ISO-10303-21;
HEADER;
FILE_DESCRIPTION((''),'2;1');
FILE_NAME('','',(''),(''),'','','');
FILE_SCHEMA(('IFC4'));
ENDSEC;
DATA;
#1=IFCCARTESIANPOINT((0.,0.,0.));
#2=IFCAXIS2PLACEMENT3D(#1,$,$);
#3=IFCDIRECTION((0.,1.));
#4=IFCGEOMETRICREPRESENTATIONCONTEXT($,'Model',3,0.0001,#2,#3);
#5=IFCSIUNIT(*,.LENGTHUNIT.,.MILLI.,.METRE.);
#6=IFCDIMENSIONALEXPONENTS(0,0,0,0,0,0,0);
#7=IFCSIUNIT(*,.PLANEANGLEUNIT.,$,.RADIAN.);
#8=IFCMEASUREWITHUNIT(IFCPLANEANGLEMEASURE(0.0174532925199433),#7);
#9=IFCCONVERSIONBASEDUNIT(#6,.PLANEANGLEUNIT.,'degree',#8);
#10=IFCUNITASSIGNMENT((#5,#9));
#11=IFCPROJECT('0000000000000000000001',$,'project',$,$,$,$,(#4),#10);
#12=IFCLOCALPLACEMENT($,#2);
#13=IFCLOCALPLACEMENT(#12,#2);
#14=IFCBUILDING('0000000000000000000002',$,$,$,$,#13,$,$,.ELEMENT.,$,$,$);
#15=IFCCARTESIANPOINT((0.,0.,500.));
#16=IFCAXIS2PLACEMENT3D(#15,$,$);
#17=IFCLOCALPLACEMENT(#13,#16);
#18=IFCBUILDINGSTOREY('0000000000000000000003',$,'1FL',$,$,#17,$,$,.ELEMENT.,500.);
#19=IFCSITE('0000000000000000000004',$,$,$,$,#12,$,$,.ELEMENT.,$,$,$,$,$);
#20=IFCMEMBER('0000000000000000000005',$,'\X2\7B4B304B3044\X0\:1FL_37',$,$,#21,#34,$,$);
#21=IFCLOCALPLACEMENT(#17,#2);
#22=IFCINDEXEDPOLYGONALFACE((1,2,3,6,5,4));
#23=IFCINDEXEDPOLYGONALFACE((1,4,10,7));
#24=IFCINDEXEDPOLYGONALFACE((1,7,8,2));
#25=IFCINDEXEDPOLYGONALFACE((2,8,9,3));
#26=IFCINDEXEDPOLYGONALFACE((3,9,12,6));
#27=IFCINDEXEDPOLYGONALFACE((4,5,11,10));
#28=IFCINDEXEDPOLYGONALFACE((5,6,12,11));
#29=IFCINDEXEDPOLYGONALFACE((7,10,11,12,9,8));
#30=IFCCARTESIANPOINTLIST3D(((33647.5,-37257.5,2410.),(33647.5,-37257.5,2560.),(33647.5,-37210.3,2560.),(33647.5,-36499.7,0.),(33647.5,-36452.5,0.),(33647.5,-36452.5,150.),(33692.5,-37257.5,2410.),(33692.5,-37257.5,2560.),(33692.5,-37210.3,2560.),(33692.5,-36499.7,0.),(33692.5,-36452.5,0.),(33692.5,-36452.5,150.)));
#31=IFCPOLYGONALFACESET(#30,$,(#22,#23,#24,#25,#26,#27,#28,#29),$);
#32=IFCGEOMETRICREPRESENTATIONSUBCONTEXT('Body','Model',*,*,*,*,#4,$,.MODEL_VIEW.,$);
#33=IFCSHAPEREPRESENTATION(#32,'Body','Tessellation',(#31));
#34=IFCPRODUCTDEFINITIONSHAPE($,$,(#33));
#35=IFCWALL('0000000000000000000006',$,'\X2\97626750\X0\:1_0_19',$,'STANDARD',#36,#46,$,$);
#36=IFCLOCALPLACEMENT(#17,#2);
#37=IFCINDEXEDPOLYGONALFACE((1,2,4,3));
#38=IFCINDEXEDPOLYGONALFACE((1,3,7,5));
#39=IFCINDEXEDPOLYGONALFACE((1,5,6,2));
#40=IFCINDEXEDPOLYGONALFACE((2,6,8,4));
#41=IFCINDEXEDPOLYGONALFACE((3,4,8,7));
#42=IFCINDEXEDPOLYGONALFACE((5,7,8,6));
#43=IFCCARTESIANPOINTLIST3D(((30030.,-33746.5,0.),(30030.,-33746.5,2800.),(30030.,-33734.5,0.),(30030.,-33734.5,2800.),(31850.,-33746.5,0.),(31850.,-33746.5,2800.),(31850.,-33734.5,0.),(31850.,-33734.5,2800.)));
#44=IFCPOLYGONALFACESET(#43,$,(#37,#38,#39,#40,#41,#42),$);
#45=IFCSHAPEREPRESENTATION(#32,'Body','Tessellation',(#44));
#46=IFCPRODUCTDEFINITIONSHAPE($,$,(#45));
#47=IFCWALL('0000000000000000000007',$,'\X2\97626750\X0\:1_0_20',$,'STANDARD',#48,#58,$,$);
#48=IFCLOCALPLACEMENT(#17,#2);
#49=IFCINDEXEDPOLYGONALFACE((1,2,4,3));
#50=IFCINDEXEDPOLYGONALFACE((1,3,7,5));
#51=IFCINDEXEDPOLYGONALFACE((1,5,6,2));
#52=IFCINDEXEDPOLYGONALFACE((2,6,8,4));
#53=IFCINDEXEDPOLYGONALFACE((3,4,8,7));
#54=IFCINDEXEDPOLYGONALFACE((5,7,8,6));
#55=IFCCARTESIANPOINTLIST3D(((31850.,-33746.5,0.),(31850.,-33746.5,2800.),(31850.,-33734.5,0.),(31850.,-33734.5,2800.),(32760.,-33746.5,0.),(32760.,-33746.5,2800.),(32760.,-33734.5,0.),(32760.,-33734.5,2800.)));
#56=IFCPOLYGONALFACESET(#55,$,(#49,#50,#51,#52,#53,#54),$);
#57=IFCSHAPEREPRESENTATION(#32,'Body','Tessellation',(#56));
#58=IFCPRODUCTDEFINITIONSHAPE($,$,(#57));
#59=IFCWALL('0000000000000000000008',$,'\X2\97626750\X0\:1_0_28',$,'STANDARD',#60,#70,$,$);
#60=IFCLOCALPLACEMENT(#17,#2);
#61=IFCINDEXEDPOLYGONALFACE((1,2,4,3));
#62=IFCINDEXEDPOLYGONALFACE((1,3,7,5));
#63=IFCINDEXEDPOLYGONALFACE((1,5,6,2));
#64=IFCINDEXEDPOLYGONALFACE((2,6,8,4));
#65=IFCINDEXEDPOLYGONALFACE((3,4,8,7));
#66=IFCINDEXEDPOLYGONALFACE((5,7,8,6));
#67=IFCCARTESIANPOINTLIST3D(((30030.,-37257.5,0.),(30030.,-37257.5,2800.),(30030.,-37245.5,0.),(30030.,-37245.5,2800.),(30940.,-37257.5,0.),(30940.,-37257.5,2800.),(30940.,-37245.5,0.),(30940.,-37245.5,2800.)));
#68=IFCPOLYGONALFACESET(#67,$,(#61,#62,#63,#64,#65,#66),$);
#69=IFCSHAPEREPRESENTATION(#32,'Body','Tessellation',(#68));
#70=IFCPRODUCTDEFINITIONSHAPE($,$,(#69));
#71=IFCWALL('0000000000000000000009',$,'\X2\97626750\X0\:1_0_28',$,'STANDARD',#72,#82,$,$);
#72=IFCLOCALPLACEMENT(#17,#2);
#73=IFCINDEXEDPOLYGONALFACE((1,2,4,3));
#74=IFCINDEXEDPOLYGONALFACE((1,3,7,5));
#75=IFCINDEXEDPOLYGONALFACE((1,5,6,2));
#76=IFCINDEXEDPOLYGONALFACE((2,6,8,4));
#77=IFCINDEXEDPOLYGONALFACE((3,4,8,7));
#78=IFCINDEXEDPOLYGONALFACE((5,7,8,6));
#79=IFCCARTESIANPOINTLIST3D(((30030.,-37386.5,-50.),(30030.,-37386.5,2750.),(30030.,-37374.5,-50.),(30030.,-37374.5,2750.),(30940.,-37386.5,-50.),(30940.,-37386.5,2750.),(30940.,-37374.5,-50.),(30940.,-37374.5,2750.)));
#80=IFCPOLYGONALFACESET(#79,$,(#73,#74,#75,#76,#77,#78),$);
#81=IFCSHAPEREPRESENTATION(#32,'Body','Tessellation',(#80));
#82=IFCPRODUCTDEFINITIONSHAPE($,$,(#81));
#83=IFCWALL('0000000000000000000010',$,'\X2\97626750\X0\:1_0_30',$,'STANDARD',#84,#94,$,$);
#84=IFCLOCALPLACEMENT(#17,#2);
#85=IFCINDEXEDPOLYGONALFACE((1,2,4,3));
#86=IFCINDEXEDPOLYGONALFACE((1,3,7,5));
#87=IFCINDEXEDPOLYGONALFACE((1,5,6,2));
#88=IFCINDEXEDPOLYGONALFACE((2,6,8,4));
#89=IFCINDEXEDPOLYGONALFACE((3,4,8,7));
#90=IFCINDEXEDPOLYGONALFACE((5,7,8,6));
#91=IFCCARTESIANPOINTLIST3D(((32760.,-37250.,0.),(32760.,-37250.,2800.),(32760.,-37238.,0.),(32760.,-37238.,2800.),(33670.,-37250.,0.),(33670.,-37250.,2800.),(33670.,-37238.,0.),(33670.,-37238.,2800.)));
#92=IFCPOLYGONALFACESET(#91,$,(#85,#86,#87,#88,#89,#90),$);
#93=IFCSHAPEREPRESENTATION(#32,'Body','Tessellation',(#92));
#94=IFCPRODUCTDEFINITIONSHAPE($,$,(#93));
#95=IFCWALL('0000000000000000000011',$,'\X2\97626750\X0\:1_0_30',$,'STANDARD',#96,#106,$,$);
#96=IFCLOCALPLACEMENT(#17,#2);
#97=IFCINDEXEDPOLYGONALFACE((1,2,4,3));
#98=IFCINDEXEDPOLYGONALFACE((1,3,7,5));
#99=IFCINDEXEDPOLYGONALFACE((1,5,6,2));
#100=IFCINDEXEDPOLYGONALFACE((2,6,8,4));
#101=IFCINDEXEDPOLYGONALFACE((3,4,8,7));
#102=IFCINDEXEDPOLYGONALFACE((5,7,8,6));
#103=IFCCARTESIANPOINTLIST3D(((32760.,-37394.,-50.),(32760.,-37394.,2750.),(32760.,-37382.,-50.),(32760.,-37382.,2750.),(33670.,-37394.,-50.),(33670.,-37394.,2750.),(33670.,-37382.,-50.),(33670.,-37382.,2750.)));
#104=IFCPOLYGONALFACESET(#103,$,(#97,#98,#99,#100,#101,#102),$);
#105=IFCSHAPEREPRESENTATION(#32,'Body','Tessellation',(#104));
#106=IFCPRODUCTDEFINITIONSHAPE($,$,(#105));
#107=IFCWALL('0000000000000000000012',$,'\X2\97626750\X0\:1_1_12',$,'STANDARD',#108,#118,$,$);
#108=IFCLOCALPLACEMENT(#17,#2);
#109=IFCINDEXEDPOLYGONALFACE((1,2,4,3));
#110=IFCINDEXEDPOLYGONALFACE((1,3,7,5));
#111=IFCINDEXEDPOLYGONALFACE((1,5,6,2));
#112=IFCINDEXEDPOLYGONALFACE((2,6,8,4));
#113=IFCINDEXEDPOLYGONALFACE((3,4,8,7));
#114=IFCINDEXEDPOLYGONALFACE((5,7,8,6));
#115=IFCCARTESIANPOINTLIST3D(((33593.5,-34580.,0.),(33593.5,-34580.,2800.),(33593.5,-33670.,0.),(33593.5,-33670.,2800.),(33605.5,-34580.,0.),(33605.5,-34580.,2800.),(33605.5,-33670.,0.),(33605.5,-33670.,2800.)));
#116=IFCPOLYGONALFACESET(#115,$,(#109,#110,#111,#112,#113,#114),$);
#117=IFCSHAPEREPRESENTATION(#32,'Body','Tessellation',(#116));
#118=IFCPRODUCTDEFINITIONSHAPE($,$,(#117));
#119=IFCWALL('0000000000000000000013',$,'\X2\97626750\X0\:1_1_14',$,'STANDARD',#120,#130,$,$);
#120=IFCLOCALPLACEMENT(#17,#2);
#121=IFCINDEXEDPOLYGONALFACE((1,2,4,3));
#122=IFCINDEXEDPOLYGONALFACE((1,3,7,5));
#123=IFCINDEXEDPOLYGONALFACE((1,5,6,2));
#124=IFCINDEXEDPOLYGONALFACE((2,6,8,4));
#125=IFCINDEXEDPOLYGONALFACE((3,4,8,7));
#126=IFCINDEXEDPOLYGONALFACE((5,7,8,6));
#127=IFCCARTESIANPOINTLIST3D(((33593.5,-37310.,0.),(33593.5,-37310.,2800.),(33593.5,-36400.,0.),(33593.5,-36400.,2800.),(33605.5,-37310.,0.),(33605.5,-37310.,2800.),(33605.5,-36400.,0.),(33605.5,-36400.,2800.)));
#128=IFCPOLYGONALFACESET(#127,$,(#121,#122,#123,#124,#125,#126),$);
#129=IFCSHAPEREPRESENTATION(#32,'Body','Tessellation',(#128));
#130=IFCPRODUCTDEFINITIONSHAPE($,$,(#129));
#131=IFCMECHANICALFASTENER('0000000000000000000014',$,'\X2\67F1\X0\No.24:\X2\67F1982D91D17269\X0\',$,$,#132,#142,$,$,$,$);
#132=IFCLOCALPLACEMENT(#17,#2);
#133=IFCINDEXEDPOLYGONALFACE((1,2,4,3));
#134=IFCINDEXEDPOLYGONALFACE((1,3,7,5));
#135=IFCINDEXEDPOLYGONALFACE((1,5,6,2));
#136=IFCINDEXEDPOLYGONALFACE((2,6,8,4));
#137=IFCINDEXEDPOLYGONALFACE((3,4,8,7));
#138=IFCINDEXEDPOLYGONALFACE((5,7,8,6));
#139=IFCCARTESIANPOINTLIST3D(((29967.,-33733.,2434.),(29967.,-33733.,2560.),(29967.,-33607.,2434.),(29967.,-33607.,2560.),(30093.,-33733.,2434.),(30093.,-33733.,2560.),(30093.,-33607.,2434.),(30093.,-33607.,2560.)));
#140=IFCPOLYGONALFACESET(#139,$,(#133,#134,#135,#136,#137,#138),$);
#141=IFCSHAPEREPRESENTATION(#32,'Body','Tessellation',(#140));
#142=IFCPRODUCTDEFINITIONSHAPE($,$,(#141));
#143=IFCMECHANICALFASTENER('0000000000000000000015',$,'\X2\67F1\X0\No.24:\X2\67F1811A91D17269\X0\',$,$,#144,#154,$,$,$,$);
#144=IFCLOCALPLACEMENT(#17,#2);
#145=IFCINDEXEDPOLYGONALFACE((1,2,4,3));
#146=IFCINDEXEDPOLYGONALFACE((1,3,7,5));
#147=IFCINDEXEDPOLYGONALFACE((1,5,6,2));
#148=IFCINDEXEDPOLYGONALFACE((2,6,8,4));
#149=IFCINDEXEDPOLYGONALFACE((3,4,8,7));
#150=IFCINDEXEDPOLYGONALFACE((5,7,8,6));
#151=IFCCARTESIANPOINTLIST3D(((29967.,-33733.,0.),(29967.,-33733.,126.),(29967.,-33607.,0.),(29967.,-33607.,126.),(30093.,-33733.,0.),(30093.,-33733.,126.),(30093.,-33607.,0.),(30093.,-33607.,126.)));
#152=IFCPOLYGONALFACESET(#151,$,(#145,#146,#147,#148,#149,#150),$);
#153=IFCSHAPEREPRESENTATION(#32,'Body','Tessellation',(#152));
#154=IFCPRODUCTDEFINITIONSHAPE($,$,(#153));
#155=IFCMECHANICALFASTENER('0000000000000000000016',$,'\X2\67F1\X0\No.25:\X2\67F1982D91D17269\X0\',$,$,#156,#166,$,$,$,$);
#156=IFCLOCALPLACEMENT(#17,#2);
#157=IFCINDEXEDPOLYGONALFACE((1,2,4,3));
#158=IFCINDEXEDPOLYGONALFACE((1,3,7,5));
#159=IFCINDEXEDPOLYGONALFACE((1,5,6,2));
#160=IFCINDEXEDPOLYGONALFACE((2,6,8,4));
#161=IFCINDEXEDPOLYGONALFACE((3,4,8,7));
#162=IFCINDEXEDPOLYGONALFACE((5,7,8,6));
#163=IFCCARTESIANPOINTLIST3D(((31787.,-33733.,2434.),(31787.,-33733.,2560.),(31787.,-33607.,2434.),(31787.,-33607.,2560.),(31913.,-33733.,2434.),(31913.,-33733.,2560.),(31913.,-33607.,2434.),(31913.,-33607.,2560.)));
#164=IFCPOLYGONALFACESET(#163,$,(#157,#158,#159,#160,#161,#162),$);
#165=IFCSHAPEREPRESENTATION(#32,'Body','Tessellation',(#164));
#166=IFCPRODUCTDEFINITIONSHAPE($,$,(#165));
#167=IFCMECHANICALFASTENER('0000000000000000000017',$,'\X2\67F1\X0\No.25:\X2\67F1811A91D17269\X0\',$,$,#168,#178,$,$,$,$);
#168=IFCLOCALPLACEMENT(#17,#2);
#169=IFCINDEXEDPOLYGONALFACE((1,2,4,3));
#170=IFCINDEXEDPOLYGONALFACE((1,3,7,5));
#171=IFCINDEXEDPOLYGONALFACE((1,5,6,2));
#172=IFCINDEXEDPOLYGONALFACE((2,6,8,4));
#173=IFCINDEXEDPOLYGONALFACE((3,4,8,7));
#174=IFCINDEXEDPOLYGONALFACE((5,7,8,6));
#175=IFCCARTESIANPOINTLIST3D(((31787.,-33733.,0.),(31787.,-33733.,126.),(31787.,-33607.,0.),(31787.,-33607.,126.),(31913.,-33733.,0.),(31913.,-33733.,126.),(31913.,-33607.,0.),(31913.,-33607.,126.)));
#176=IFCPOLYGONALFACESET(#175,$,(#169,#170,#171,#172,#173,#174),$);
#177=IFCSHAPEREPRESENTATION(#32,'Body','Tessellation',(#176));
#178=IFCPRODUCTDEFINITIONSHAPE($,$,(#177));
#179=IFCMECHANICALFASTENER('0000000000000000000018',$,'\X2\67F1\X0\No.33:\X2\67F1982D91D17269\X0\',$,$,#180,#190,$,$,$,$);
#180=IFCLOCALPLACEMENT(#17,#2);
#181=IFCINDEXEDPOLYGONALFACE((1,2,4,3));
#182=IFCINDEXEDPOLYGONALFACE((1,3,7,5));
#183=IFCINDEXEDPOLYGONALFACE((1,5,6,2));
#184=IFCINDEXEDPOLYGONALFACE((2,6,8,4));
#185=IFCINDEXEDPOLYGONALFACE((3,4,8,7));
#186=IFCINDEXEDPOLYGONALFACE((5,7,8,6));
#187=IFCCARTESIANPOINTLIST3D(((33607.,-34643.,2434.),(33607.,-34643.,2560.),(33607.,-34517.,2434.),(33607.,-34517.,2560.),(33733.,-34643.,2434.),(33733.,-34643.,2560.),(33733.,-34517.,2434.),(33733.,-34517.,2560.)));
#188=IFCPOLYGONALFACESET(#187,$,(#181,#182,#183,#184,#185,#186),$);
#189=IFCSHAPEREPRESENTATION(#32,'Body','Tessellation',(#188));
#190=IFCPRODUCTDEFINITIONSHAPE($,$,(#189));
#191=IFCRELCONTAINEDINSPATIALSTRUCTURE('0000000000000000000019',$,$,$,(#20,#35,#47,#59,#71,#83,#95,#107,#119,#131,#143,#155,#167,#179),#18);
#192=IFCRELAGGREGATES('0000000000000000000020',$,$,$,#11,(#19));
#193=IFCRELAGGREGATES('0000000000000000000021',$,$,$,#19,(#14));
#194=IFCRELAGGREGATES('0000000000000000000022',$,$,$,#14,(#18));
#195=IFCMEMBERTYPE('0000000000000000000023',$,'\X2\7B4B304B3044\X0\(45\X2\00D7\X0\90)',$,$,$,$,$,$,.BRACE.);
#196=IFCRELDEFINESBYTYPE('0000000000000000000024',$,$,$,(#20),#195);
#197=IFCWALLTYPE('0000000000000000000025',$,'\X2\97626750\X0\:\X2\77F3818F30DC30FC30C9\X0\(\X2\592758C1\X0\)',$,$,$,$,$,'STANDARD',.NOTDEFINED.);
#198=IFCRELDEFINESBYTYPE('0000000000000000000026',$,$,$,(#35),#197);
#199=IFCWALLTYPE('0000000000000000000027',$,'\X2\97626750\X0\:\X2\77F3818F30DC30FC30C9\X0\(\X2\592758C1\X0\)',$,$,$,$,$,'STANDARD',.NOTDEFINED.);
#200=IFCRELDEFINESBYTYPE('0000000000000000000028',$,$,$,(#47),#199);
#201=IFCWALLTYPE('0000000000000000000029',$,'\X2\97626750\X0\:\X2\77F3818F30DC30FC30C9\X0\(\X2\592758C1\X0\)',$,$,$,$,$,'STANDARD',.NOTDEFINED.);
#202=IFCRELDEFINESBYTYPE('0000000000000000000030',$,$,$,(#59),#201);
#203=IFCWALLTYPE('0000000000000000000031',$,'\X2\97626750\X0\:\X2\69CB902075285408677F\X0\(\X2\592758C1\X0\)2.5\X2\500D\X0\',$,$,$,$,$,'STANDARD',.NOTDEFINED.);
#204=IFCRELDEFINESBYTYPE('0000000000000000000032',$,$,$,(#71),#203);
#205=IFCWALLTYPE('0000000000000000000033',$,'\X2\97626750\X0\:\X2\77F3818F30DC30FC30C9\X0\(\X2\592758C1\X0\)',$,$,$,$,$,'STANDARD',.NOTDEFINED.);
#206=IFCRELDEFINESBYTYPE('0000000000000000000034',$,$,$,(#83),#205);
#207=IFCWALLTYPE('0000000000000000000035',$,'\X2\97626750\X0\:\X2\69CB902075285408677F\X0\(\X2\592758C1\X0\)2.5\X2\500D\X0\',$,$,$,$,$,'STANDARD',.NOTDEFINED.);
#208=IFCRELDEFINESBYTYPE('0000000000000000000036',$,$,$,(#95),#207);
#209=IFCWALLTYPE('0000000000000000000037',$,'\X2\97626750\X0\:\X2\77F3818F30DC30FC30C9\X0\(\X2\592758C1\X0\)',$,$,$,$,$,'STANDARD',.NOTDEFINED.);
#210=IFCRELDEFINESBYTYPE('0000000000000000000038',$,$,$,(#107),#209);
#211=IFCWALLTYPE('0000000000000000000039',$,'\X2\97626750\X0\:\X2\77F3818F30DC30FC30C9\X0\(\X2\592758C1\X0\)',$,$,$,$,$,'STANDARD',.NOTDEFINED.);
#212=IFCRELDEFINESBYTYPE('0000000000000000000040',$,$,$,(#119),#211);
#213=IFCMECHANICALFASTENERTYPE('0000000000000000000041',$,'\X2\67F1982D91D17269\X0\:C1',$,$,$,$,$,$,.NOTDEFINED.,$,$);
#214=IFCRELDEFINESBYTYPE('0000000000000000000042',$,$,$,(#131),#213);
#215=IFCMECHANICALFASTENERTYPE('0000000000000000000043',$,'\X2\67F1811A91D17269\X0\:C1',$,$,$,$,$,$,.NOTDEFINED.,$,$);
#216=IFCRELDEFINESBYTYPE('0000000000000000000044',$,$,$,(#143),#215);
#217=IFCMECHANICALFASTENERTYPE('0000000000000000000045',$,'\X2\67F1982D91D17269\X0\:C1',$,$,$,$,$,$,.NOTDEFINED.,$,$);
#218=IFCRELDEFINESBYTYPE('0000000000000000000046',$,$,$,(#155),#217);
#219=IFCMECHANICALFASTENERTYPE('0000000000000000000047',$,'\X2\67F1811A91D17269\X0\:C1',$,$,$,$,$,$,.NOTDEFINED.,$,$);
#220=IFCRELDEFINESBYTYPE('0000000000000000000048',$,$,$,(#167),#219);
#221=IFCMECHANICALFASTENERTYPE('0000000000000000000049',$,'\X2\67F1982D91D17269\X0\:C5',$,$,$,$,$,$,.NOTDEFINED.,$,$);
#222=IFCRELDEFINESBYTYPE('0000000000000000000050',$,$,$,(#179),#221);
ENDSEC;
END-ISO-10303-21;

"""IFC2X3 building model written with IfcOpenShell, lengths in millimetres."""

from ifc_helpers import new_model, entity, si_unit, converted_unit, direction, frame, origin, origin_with_axes, origin_2d, place, context, subcontext, project, spatial, polyline, rectangle, outline, extrude, type_object, element, save


model = new_model("IFC2X3")

# Units and contexts
model_context = context("Model", 3, precision=0.0001, world=origin(), true_north=direction((0.0, 1.0)))
body_context = subcontext(model_context, "Body", "Model", "MODEL_VIEW")
ifc_project = project(units=[si_unit("LENGTHUNIT", "METRE", prefix="MILLI"), converted_unit("PLANEANGLEUNIT", "degree", entity("IfcPlaneAngleMeasure", 0.0174532925199433), si_unit("PLANEANGLEUNIT", "RADIAN"), dimensions=[0, 0, 0, 0, 0, 0, 0])], contexts=[model_context])

# Site, building, storey
site_placement = place(None, origin())
site = spatial("IfcSite", under=ifc_project, at=site_placement, CompositionType="ELEMENT")
building_placement = place(site_placement, origin())
building = spatial("IfcBuilding", under=site, at=building_placement, CompositionType="ELEMENT")
storey_placement = place(building_placement, frame((0.0, 0.0, 500.0)))
storey = spatial("IfcBuildingStorey", under=building, at=storey_placement, Name="1FL", CompositionType="ELEMENT", Elevation=500.0)

# Member
member_type_1 = type_object("IfcMemberType", Name="筋かい(45×90)", PredefinedType="BRACE")
member_1_placement = place(storey_placement, frame((33670.0, -36452.5, 0.0), z_axis=(0.0, -0.299972, 0.953948), x_axis=(0.0, 0.953948, 0.299972)))
element("IfcMember", 1, at=member_1_placement, inside=storey, type_object=member_type_1, Name="筋かい:1FL_37", context=body_context, shape_type="SweptSolid", body=[
    extrude(outline(polyline([(0.0, 0.0), (14.2, -45.0), (2540.5, -45.0), (2683.6, 0.0), (2669.4, 45.0), (143.1, 45.0), (0.0, 0.0)])), frame((0.0, -22.5, 0.0), z_axis=(0.0, 1.0, 0.0), x_axis=(0.0, 0.0, 1.0)), (0.0, 0.0, 1.0), 45.0),
])

# Walls
wall_type_1 = type_object("IfcWallType", Name="面材:石膏ボード(大壁)", ElementType="STANDARD", PredefinedType="NOTDEFINED")
wall_1_placement = place(storey_placement, frame((30940.0, -33734.5, 0.0), z_axis=(0.0, -1.0, 0.0), x_axis=(1.0, 0.0, 0.0)))
element("IfcWall", 2, at=wall_1_placement, inside=storey, type_object=wall_type_1, Name="面材:1_0_19", ObjectType="STANDARD", context=body_context, shape_type="SweptSolid", body=[
    extrude(outline(polyline([(910.0, 0.0, 0.0), (-910.0, 0.0, 0.0), (-910.0, 2800.0, 0.0), (910.0, 2800.0, 0.0), (910.0, 0.0, 0.0)])), origin_with_axes(), (0.0, 0.0, 1.0), 12.0),
])
wall_type_2 = type_object("IfcWallType", Name="面材:石膏ボード(大壁)", ElementType="STANDARD", PredefinedType="NOTDEFINED")
wall_2_placement = place(storey_placement, frame((32305.0, -33734.5, 0.0), z_axis=(0.0, -1.0, 0.0), x_axis=(1.0, 0.0, 0.0)))
element("IfcWall", 3, at=wall_2_placement, inside=storey, type_object=wall_type_2, Name="面材:1_0_20", ObjectType="STANDARD", context=body_context, shape_type="SweptSolid", body=[
    extrude(outline(polyline([(455.0, 0.0, 0.0), (-455.0, 0.0, 0.0), (-455.0, 2800.0, 0.0), (455.0, 2800.0, 0.0), (455.0, 0.0, 0.0)])), origin_with_axes(), (0.0, 0.0, 1.0), 12.0),
])
wall_type_3 = type_object("IfcWallType", Name="面材:石膏ボード(大壁)", ElementType="STANDARD", PredefinedType="NOTDEFINED")
wall_3_placement = place(storey_placement, frame((30485.0, -37245.5, 0.0), z_axis=(0.0, -1.0, 0.0), x_axis=(1.0, 0.0, 0.0)))
element("IfcWall", 4, at=wall_3_placement, inside=storey, type_object=wall_type_3, Name="面材:1_0_28", ObjectType="STANDARD", context=body_context, shape_type="SweptSolid", body=[
    extrude(outline(polyline([(455.0, 0.0, 0.0), (-455.0, 0.0, 0.0), (-455.0, 2800.0, 0.0), (455.0, 2800.0, 0.0), (455.0, 0.0, 0.0)])), origin_with_axes(), (0.0, 0.0, 1.0), 12.0),
])
wall_type_4 = type_object("IfcWallType", Name="面材:構造用合板(大壁)2.5倍", ElementType="STANDARD", PredefinedType="NOTDEFINED")
wall_4_placement = place(storey_placement, frame((30485.0, -37374.5, -50.0), z_axis=(0.0, -1.0, 0.0), x_axis=(1.0, 0.0, 0.0)))
element("IfcWall", 5, at=wall_4_placement, inside=storey, type_object=wall_type_4, Name="面材:1_0_28", ObjectType="STANDARD", context=body_context, shape_type="SweptSolid", body=[
    extrude(outline(polyline([(455.0, 0.0, 0.0), (-455.0, 0.0, 0.0), (-455.0, 2800.0, 0.0), (455.0, 2800.0, 0.0), (455.0, 0.0, 0.0)])), origin_with_axes(), (0.0, 0.0, 1.0), 12.0),
])
wall_type_5 = type_object("IfcWallType", Name="面材:石膏ボード(大壁)", ElementType="STANDARD", PredefinedType="NOTDEFINED")
wall_5_placement = place(storey_placement, frame((33215.0, -37238.0, 0.0), z_axis=(0.0, -1.0, 0.0), x_axis=(1.0, 0.0, 0.0)))
element("IfcWall", 6, at=wall_5_placement, inside=storey, type_object=wall_type_5, Name="面材:1_0_30", ObjectType="STANDARD", context=body_context, shape_type="SweptSolid", body=[
    extrude(outline(polyline([(455.0, 0.0, 0.0), (-455.0, 0.0, 0.0), (-455.0, 2800.0, 0.0), (455.0, 2800.0, 0.0), (455.0, 0.0, 0.0)])), origin_with_axes(), (0.0, 0.0, 1.0), 12.0),
])
wall_type_6 = type_object("IfcWallType", Name="面材:構造用合板(大壁)2.5倍", ElementType="STANDARD", PredefinedType="NOTDEFINED")
wall_6_placement = place(storey_placement, frame((33215.0, -37382.0, -50.0), z_axis=(0.0, -1.0, 0.0), x_axis=(1.0, 0.0, 0.0)))
element("IfcWall", 7, at=wall_6_placement, inside=storey, type_object=wall_type_6, Name="面材:1_0_30", ObjectType="STANDARD", context=body_context, shape_type="SweptSolid", body=[
    extrude(outline(polyline([(455.0, 0.0, 0.0), (-455.0, 0.0, 0.0), (-455.0, 2800.0, 0.0), (455.0, 2800.0, 0.0), (455.0, 0.0, 0.0)])), origin_with_axes(), (0.0, 0.0, 1.0), 12.0),
])
wall_type_7 = type_object("IfcWallType", Name="面材:石膏ボード(大壁)", ElementType="STANDARD", PredefinedType="NOTDEFINED")
wall_7_placement = place(storey_placement, frame((33605.5, -34125.0, 0.0), z_axis=(-1.0, 0.0, 0.0), x_axis=(0.0, -1.0, 0.0)))
element("IfcWall", 8, at=wall_7_placement, inside=storey, type_object=wall_type_7, Name="面材:1_1_12", ObjectType="STANDARD", context=body_context, shape_type="SweptSolid", body=[
    extrude(outline(polyline([(455.0, 0.0, 0.0), (-455.0, 0.0, 0.0), (-455.0, 2800.0, 0.0), (455.0, 2800.0, 0.0), (455.0, 0.0, 0.0)])), origin_with_axes(), (0.0, 0.0, 1.0), 12.0),
])
wall_type_8 = type_object("IfcWallType", Name="面材:石膏ボード(大壁)", ElementType="STANDARD", PredefinedType="NOTDEFINED")
wall_8_placement = place(storey_placement, frame((33605.5, -36855.0, 0.0), z_axis=(-1.0, 0.0, 0.0), x_axis=(0.0, -1.0, 0.0)))
element("IfcWall", 9, at=wall_8_placement, inside=storey, type_object=wall_type_8, Name="面材:1_1_14", ObjectType="STANDARD", context=body_context, shape_type="SweptSolid", body=[
    extrude(outline(polyline([(455.0, 0.0, 0.0), (-455.0, 0.0, 0.0), (-455.0, 2800.0, 0.0), (455.0, 2800.0, 0.0), (455.0, 0.0, 0.0)])), origin_with_axes(), (0.0, 0.0, 1.0), 12.0),
])

# Mechanical fasteners
mechanical_fastener_type_1 = type_object("IfcMechanicalFastenerType", Name="柱頭金物:C1")
mechanical_fastener_1_placement = place(storey_placement, frame((30030.0, -33670.0, 2434.0)))
element("IfcMechanicalFastener", 10, at=mechanical_fastener_1_placement, inside=storey, type_object=mechanical_fastener_type_1, Name="柱No.24:柱頭金物", context=body_context, shape_type="SweptSolid", body=[
    extrude(rectangle(XDim=126.0, YDim=126.0, at=origin_2d()), origin_with_axes(), (0.0, 0.0, 1.0), 126.0),
])
mechanical_fastener_type_2 = type_object("IfcMechanicalFastenerType", Name="柱脚金物:C1")
mechanical_fastener_2_placement = place(storey_placement, frame((30030.0, -33670.0, 0.0)))
element("IfcMechanicalFastener", 11, at=mechanical_fastener_2_placement, inside=storey, type_object=mechanical_fastener_type_2, Name="柱No.24:柱脚金物", context=body_context, shape_type="SweptSolid", body=[
    extrude(rectangle(XDim=126.0, YDim=126.0, at=origin_2d()), origin_with_axes(), (0.0, 0.0, 1.0), 126.0),
])
mechanical_fastener_type_3 = type_object("IfcMechanicalFastenerType", Name="柱頭金物:C1")
mechanical_fastener_3_placement = place(storey_placement, frame((31850.0, -33670.0, 2434.0)))
element("IfcMechanicalFastener", 12, at=mechanical_fastener_3_placement, inside=storey, type_object=mechanical_fastener_type_3, Name="柱No.25:柱頭金物", context=body_context, shape_type="SweptSolid", body=[
    extrude(rectangle(XDim=126.0, YDim=126.0, at=origin_2d()), origin_with_axes(), (0.0, 0.0, 1.0), 126.0),
])
mechanical_fastener_type_4 = type_object("IfcMechanicalFastenerType", Name="柱脚金物:C1")
mechanical_fastener_4_placement = place(storey_placement, frame((31850.0, -33670.0, 0.0)))
element("IfcMechanicalFastener", 13, at=mechanical_fastener_4_placement, inside=storey, type_object=mechanical_fastener_type_4, Name="柱No.25:柱脚金物", context=body_context, shape_type="SweptSolid", body=[
    extrude(rectangle(XDim=126.0, YDim=126.0, at=origin_2d()), origin_with_axes(), (0.0, 0.0, 1.0), 126.0),
])
mechanical_fastener_type_5 = type_object("IfcMechanicalFastenerType", Name="柱頭金物:C5")
mechanical_fastener_5_placement = place(storey_placement, frame((33670.0, -34580.0, 2434.0)))
element("IfcMechanicalFastener", 14, at=mechanical_fastener_5_placement, inside=storey, type_object=mechanical_fastener_type_5, Name="柱No.33:柱頭金物", context=body_context, shape_type="SweptSolid", body=[
    extrude(rectangle(XDim=126.0, YDim=126.0, at=origin_2d()), origin_with_axes(), (0.0, 0.0, 1.0), 126.0),
])

save(model, "model.ifc")
